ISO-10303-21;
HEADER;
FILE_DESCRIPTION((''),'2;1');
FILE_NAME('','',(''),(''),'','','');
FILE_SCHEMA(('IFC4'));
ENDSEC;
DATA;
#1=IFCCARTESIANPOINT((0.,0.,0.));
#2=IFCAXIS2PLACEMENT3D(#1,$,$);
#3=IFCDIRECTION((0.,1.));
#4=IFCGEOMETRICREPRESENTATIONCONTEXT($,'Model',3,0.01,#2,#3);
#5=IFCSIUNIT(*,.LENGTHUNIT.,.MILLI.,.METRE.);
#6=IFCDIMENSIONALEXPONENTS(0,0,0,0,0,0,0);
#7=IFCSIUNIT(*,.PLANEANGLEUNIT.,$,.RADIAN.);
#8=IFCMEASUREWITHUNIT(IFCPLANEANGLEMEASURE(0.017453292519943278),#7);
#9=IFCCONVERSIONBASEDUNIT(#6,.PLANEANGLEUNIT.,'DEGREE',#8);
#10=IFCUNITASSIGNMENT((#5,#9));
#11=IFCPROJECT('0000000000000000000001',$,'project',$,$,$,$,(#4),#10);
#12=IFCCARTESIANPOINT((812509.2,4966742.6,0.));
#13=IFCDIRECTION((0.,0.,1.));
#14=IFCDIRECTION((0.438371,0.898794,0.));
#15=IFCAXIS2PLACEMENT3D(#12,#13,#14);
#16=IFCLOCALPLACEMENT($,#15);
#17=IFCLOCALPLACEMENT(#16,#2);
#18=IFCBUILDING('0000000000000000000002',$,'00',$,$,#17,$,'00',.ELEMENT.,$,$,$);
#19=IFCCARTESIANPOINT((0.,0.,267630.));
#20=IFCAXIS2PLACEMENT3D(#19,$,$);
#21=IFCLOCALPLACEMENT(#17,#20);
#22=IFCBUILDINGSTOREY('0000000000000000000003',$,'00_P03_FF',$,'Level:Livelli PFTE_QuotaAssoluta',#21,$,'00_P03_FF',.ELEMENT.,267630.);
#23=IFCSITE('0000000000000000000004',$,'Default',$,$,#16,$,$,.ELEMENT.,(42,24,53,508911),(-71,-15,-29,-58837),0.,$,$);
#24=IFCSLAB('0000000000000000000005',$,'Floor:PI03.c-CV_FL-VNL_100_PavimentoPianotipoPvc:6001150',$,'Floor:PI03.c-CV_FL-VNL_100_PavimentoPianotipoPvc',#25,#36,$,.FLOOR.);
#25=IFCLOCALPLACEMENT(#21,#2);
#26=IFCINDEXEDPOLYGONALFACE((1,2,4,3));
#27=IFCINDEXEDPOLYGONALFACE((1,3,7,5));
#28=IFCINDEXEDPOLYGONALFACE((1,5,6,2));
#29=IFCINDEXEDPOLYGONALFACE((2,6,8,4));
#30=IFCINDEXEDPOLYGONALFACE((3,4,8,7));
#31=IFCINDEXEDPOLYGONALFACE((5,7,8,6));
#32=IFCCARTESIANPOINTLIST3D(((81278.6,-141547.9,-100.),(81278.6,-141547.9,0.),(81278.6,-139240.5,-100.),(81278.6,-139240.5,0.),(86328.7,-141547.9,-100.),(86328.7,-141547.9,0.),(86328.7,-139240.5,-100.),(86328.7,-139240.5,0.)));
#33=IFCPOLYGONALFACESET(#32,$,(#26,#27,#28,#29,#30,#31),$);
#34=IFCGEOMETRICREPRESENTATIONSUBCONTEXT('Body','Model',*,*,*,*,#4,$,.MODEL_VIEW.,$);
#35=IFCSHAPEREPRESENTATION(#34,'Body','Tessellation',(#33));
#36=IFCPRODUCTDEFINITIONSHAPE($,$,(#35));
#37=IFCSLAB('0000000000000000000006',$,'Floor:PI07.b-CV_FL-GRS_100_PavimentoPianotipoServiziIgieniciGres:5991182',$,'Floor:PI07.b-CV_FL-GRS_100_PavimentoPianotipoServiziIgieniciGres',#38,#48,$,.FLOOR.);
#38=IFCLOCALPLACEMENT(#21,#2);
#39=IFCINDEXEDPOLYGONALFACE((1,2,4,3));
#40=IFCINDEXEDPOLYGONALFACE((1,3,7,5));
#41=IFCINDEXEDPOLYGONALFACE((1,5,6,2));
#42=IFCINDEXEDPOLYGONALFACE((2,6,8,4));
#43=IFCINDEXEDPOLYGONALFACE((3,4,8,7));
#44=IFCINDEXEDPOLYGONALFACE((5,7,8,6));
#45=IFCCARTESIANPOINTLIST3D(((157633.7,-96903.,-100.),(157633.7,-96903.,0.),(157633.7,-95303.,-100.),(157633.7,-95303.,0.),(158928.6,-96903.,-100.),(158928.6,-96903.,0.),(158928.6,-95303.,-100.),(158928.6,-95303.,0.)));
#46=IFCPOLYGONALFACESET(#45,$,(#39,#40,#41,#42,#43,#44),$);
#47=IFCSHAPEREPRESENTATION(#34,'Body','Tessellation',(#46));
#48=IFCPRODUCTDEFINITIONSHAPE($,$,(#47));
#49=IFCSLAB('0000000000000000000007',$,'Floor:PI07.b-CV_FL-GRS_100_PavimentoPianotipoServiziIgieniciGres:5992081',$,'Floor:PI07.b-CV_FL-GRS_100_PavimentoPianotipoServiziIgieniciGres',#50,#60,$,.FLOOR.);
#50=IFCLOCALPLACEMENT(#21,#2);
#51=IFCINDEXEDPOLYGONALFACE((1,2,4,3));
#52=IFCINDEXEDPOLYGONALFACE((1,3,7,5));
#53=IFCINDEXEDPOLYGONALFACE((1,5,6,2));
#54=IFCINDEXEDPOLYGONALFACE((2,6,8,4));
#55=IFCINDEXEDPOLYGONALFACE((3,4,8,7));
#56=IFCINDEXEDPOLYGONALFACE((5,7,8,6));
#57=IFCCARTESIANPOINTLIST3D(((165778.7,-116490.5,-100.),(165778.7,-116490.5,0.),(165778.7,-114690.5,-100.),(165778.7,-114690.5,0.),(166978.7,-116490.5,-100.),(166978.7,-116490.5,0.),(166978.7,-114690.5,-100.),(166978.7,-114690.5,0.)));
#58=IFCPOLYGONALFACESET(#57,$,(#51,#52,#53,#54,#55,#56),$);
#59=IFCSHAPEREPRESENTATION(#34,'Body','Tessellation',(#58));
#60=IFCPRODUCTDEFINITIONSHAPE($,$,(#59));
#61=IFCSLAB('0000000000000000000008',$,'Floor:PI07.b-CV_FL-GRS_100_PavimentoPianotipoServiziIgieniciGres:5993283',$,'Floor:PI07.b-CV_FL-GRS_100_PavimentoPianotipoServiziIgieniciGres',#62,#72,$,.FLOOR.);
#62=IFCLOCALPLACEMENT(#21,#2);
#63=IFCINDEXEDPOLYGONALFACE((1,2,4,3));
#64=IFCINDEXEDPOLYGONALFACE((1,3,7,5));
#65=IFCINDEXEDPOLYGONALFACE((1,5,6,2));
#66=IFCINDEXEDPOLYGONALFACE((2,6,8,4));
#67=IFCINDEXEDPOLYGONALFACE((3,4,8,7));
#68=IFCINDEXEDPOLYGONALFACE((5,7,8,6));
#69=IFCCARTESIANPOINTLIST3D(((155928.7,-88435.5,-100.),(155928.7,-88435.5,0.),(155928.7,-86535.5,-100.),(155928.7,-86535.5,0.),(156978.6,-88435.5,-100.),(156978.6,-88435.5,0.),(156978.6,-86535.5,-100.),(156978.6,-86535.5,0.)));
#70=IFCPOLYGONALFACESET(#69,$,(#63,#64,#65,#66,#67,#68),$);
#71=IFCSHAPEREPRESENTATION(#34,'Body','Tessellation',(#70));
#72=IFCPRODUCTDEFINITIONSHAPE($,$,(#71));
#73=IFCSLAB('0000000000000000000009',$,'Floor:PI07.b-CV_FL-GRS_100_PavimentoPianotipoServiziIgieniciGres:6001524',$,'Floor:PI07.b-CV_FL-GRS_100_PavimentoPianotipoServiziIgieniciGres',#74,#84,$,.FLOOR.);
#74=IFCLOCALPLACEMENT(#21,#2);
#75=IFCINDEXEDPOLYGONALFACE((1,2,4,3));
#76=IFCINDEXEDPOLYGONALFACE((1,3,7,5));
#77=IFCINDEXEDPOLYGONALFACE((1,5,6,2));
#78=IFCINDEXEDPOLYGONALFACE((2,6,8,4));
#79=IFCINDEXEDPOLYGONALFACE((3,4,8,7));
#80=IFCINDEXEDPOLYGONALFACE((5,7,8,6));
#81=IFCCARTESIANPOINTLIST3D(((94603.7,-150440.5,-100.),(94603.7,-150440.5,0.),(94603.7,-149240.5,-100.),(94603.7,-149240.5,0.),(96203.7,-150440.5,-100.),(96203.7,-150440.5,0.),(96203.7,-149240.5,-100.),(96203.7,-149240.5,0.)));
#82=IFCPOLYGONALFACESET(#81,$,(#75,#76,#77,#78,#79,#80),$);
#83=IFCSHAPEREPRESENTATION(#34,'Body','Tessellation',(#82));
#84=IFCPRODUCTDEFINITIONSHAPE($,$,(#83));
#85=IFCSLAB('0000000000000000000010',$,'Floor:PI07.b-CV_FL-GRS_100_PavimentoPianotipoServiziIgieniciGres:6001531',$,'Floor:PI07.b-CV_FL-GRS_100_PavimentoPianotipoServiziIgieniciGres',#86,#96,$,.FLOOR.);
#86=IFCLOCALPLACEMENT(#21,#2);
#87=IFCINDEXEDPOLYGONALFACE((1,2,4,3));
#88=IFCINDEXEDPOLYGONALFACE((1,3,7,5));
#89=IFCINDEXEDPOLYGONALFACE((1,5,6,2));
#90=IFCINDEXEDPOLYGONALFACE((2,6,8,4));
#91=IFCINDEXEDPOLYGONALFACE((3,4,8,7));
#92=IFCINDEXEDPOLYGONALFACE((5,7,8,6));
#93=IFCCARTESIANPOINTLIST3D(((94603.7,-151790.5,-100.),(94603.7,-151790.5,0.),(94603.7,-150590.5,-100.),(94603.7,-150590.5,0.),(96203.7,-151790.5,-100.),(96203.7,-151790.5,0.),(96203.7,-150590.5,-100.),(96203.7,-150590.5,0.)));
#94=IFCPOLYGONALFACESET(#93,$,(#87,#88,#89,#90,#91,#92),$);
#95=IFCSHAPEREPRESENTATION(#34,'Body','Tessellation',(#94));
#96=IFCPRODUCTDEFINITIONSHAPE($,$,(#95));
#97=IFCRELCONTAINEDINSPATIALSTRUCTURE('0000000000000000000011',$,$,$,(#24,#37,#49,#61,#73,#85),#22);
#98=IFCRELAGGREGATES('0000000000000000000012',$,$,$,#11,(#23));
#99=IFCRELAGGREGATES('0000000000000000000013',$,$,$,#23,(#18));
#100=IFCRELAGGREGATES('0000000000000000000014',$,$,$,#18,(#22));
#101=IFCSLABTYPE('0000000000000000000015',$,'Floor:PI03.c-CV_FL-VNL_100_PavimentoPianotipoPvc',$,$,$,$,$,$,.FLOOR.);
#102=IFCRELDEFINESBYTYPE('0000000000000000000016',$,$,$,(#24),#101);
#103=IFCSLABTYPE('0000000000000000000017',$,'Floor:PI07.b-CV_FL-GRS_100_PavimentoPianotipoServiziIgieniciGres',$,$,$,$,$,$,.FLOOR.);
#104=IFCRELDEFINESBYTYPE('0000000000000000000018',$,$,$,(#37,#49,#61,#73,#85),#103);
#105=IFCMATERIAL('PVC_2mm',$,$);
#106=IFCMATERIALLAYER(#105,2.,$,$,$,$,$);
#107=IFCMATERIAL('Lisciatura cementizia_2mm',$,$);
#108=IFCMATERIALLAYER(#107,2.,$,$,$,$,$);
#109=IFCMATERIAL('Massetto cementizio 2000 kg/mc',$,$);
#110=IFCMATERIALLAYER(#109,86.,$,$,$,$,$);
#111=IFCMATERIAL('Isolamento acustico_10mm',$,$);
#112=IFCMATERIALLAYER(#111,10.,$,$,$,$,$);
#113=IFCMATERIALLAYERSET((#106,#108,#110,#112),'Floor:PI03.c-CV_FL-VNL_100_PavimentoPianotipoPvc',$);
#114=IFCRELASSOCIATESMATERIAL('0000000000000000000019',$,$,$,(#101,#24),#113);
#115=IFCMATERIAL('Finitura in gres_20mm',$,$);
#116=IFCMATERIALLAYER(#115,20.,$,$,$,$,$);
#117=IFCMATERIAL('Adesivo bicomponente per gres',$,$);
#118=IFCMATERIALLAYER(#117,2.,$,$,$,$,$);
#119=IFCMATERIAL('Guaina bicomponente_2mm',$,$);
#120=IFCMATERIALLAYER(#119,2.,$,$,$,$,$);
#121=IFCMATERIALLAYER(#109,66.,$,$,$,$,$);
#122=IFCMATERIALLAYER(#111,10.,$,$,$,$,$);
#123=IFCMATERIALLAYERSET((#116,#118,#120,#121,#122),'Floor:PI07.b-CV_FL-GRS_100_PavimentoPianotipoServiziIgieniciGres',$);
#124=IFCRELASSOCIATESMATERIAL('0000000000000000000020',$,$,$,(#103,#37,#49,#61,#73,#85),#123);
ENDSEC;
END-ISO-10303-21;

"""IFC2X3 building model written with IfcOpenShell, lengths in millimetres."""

from ifc_helpers import new_model, entity, si_unit, converted_unit, direction, frame, frame_2d, origin, origin_2d_with_axis, place, context, subcontext, project, spatial, rectangle, extrude, material, layer, layer_set, layer_usage, type_object, element, save


model = new_model("IFC2X3")

# Units and contexts
model_context = context("Model", 3, precision=0.01, world=origin(), true_north=direction((0.0, 1.0)))
body_context = subcontext(model_context, "Body", "Model", "MODEL_VIEW")
ifc_project = project(units=[si_unit("LENGTHUNIT", "METRE", prefix="MILLI"), converted_unit("PLANEANGLEUNIT", "DEGREE", entity("IfcPlaneAngleMeasure", 0.017453292519943278), si_unit("PLANEANGLEUNIT", "RADIAN"), dimensions=[0, 0, 0, 0, 0, 0, 0])], contexts=[model_context])

# Site, building, storey
site_placement = place(None, frame((812509.2, 4966742.6, 0.0), z_axis=(0.0, 0.0, 1.0), x_axis=(0.438371, 0.898794, 0.0)))
site = spatial("IfcSite", under=ifc_project, at=site_placement, Name="Default", CompositionType="ELEMENT", RefLatitude=(42, 24, 53, 508911), RefLongitude=(-71, -15, -29, -58837), RefElevation=0.0)
building_placement = place(site_placement, origin())
building = spatial("IfcBuilding", under=site, at=building_placement, Name="00", LongName="00", CompositionType="ELEMENT")
storey_placement = place(building_placement, frame((0.0, 0.0, 267630.0)))
storey = spatial("IfcBuildingStorey", under=building, at=storey_placement, Name="00_P03_FF", ObjectType="Level:Livelli PFTE_QuotaAssoluta", LongName="00_P03_FF", CompositionType="ELEMENT", Elevation=267630.0)

# Slabs
ifc_material_1 = material(Name="PVC_2mm")
ifc_layer_1 = layer(ifc_material_1, 2.0)
ifc_material_2 = material(Name="Lisciatura cementizia_2mm")
ifc_layer_2 = layer(ifc_material_2, 2.0)
ifc_material_3 = material(Name="Massetto cementizio 2000 kg/mc")
ifc_layer_3 = layer(ifc_material_3, 86.0)
ifc_material_4 = material(Name="Isolamento acustico_10mm")
ifc_layer_4 = layer(ifc_material_4, 10.0)
ifc_layer_set_1 = layer_set([ifc_layer_1, ifc_layer_2, ifc_layer_3, ifc_layer_4], Name="Floor:PI03.c-CV_FL-VNL_100_PavimentoPianotipoPvc")
slab_type_1 = type_object("IfcSlabType", Name="Floor:PI03.c-CV_FL-VNL_100_PavimentoPianotipoPvc", PredefinedType="FLOOR", material=ifc_layer_set_1)
ifc_layer_usage_1 = layer_usage(ifc_layer_set_1, "AXIS3", "POSITIVE", 0.0)
slab_1_placement = place(storey_placement, origin())
element("IfcSlab", 1, at=slab_1_placement, inside=storey, type_object=slab_type_1, material=ifc_layer_usage_1, Name="Floor:PI03.c-CV_FL-VNL_100_PavimentoPianotipoPvc:6001150", ObjectType="Floor:PI03.c-CV_FL-VNL_100_PavimentoPianotipoPvc", PredefinedType="FLOOR", context=body_context, shape_type="SweptSolid", body=[
    extrude(rectangle(XDim=2307.4, YDim=5050.1, at=origin_2d_with_axis()), frame((83803.7, -140394.2, 0.0), z_axis=(0.0, 0.0, -1.0), x_axis=(0.0, 1.0, 0.0)), (0.0, 0.0, 1.0), 100.0),
])
ifc_material_5 = material(Name="Finitura in gres_20mm")
ifc_layer_5 = layer(ifc_material_5, 20.0)
ifc_material_6 = material(Name="Adesivo bicomponente per gres")
ifc_layer_6 = layer(ifc_material_6, 2.0)
ifc_material_7 = material(Name="Guaina bicomponente_2mm")
ifc_layer_7 = layer(ifc_material_7, 2.0)
ifc_layer_8 = layer(ifc_material_3, 66.0)
ifc_layer_9 = layer(ifc_material_4, 10.0)
ifc_layer_set_2 = layer_set([ifc_layer_5, ifc_layer_6, ifc_layer_7, ifc_layer_8, ifc_layer_9], Name="Floor:PI07.b-CV_FL-GRS_100_PavimentoPianotipoServiziIgieniciGres")
ifc_layer_usage_2 = layer_usage(ifc_layer_set_2, "AXIS3", "POSITIVE", 0.0)
slab_type_2 = type_object("IfcSlabType", Name="Floor:PI07.b-CV_FL-GRS_100_PavimentoPianotipoServiziIgieniciGres", PredefinedType="FLOOR", material=ifc_layer_set_2)
slab_2_placement = place(storey_placement, origin())
element("IfcSlab", 2, at=slab_2_placement, inside=storey, type_object=slab_type_2, material=ifc_layer_usage_2, Name="Floor:PI07.b-CV_FL-GRS_100_PavimentoPianotipoServiziIgieniciGres:5991182", ObjectType="Floor:PI07.b-CV_FL-GRS_100_PavimentoPianotipoServiziIgieniciGres", PredefinedType="FLOOR", context=body_context, shape_type="SweptSolid", body=[
    extrude(rectangle(XDim=1600.0, YDim=1295.0, at=frame_2d((0.0, 0.0), x_axis=(1.0, 0.0))), frame((158281.2, -96103.0, 0.0), z_axis=(0.0, 0.0, -1.0), x_axis=(0.0, 1.0, 0.0)), (0.0, 0.0, 1.0), 100.0),
])
ifc_layer_usage_3 = layer_usage(ifc_layer_set_2, "AXIS3", "POSITIVE", 0.0)
slab_3_placement = place(storey_placement, origin())
element("IfcSlab", 3, at=slab_3_placement, inside=storey, type_object=slab_type_2, material=ifc_layer_usage_3, Name="Floor:PI07.b-CV_FL-GRS_100_PavimentoPianotipoServiziIgieniciGres:5992081", ObjectType="Floor:PI07.b-CV_FL-GRS_100_PavimentoPianotipoServiziIgieniciGres", PredefinedType="FLOOR", context=body_context, shape_type="SweptSolid", body=[
    extrude(rectangle(XDim=1800.0, YDim=1200.0, at=frame_2d((0.0, 0.0), x_axis=(1.0, 0.0))), frame((166378.7, -115590.5, 0.0), z_axis=(0.0, 0.0, -1.0), x_axis=(0.0, 1.0, 0.0)), (0.0, 0.0, 1.0), 100.0),
])
ifc_layer_usage_4 = layer_usage(ifc_layer_set_2, "AXIS3", "POSITIVE", 0.0)
slab_4_placement = place(storey_placement, origin())
element("IfcSlab", 4, at=slab_4_placement, inside=storey, type_object=slab_type_2, material=ifc_layer_usage_4, Name="Floor:PI07.b-CV_FL-GRS_100_PavimentoPianotipoServiziIgieniciGres:5993283", ObjectType="Floor:PI07.b-CV_FL-GRS_100_PavimentoPianotipoServiziIgieniciGres", PredefinedType="FLOOR", context=body_context, shape_type="SweptSolid", body=[
    extrude(rectangle(XDim=1900.0, YDim=1050.0, at=frame_2d((0.0, 0.0), x_axis=(1.0, 0.0))), frame((156453.7, -87485.5, 0.0), z_axis=(0.0, 0.0, -1.0), x_axis=(0.0, 1.0, 0.0)), (0.0, 0.0, 1.0), 100.0),
])
ifc_layer_usage_5 = layer_usage(ifc_layer_set_2, "AXIS3", "POSITIVE", 0.0)
slab_5_placement = place(storey_placement, origin())
element("IfcSlab", 5, at=slab_5_placement, inside=storey, type_object=slab_type_2, material=ifc_layer_usage_5, Name="Floor:PI07.b-CV_FL-GRS_100_PavimentoPianotipoServiziIgieniciGres:6001524", ObjectType="Floor:PI07.b-CV_FL-GRS_100_PavimentoPianotipoServiziIgieniciGres", PredefinedType="FLOOR", context=body_context, shape_type="SweptSolid", body=[
    extrude(rectangle(XDim=1200.0, YDim=1600.0, at=origin_2d_with_axis()), frame((95403.7, -149840.5, 0.0), z_axis=(0.0, 0.0, -1.0), x_axis=(0.0, 1.0, 0.0)), (0.0, 0.0, 1.0), 100.0),
])
ifc_layer_usage_6 = layer_usage(ifc_layer_set_2, "AXIS3", "POSITIVE", 0.0)
slab_6_placement = place(storey_placement, origin())
element("IfcSlab", 6, at=slab_6_placement, inside=storey, type_object=slab_type_2, material=ifc_layer_usage_6, Name="Floor:PI07.b-CV_FL-GRS_100_PavimentoPianotipoServiziIgieniciGres:6001531", ObjectType="Floor:PI07.b-CV_FL-GRS_100_PavimentoPianotipoServiziIgieniciGres", PredefinedType="FLOOR", context=body_context, shape_type="SweptSolid", body=[
    extrude(rectangle(XDim=1200.0, YDim=1600.0, at=frame_2d((0.0, 0.0), x_axis=(1.0, 0.0))), frame((95403.7, -151190.5, 0.0), z_axis=(0.0, 0.0, -1.0), x_axis=(0.0, 1.0, 0.0)), (0.0, 0.0, 1.0), 100.0),
])

save(model, "model.ifc")
